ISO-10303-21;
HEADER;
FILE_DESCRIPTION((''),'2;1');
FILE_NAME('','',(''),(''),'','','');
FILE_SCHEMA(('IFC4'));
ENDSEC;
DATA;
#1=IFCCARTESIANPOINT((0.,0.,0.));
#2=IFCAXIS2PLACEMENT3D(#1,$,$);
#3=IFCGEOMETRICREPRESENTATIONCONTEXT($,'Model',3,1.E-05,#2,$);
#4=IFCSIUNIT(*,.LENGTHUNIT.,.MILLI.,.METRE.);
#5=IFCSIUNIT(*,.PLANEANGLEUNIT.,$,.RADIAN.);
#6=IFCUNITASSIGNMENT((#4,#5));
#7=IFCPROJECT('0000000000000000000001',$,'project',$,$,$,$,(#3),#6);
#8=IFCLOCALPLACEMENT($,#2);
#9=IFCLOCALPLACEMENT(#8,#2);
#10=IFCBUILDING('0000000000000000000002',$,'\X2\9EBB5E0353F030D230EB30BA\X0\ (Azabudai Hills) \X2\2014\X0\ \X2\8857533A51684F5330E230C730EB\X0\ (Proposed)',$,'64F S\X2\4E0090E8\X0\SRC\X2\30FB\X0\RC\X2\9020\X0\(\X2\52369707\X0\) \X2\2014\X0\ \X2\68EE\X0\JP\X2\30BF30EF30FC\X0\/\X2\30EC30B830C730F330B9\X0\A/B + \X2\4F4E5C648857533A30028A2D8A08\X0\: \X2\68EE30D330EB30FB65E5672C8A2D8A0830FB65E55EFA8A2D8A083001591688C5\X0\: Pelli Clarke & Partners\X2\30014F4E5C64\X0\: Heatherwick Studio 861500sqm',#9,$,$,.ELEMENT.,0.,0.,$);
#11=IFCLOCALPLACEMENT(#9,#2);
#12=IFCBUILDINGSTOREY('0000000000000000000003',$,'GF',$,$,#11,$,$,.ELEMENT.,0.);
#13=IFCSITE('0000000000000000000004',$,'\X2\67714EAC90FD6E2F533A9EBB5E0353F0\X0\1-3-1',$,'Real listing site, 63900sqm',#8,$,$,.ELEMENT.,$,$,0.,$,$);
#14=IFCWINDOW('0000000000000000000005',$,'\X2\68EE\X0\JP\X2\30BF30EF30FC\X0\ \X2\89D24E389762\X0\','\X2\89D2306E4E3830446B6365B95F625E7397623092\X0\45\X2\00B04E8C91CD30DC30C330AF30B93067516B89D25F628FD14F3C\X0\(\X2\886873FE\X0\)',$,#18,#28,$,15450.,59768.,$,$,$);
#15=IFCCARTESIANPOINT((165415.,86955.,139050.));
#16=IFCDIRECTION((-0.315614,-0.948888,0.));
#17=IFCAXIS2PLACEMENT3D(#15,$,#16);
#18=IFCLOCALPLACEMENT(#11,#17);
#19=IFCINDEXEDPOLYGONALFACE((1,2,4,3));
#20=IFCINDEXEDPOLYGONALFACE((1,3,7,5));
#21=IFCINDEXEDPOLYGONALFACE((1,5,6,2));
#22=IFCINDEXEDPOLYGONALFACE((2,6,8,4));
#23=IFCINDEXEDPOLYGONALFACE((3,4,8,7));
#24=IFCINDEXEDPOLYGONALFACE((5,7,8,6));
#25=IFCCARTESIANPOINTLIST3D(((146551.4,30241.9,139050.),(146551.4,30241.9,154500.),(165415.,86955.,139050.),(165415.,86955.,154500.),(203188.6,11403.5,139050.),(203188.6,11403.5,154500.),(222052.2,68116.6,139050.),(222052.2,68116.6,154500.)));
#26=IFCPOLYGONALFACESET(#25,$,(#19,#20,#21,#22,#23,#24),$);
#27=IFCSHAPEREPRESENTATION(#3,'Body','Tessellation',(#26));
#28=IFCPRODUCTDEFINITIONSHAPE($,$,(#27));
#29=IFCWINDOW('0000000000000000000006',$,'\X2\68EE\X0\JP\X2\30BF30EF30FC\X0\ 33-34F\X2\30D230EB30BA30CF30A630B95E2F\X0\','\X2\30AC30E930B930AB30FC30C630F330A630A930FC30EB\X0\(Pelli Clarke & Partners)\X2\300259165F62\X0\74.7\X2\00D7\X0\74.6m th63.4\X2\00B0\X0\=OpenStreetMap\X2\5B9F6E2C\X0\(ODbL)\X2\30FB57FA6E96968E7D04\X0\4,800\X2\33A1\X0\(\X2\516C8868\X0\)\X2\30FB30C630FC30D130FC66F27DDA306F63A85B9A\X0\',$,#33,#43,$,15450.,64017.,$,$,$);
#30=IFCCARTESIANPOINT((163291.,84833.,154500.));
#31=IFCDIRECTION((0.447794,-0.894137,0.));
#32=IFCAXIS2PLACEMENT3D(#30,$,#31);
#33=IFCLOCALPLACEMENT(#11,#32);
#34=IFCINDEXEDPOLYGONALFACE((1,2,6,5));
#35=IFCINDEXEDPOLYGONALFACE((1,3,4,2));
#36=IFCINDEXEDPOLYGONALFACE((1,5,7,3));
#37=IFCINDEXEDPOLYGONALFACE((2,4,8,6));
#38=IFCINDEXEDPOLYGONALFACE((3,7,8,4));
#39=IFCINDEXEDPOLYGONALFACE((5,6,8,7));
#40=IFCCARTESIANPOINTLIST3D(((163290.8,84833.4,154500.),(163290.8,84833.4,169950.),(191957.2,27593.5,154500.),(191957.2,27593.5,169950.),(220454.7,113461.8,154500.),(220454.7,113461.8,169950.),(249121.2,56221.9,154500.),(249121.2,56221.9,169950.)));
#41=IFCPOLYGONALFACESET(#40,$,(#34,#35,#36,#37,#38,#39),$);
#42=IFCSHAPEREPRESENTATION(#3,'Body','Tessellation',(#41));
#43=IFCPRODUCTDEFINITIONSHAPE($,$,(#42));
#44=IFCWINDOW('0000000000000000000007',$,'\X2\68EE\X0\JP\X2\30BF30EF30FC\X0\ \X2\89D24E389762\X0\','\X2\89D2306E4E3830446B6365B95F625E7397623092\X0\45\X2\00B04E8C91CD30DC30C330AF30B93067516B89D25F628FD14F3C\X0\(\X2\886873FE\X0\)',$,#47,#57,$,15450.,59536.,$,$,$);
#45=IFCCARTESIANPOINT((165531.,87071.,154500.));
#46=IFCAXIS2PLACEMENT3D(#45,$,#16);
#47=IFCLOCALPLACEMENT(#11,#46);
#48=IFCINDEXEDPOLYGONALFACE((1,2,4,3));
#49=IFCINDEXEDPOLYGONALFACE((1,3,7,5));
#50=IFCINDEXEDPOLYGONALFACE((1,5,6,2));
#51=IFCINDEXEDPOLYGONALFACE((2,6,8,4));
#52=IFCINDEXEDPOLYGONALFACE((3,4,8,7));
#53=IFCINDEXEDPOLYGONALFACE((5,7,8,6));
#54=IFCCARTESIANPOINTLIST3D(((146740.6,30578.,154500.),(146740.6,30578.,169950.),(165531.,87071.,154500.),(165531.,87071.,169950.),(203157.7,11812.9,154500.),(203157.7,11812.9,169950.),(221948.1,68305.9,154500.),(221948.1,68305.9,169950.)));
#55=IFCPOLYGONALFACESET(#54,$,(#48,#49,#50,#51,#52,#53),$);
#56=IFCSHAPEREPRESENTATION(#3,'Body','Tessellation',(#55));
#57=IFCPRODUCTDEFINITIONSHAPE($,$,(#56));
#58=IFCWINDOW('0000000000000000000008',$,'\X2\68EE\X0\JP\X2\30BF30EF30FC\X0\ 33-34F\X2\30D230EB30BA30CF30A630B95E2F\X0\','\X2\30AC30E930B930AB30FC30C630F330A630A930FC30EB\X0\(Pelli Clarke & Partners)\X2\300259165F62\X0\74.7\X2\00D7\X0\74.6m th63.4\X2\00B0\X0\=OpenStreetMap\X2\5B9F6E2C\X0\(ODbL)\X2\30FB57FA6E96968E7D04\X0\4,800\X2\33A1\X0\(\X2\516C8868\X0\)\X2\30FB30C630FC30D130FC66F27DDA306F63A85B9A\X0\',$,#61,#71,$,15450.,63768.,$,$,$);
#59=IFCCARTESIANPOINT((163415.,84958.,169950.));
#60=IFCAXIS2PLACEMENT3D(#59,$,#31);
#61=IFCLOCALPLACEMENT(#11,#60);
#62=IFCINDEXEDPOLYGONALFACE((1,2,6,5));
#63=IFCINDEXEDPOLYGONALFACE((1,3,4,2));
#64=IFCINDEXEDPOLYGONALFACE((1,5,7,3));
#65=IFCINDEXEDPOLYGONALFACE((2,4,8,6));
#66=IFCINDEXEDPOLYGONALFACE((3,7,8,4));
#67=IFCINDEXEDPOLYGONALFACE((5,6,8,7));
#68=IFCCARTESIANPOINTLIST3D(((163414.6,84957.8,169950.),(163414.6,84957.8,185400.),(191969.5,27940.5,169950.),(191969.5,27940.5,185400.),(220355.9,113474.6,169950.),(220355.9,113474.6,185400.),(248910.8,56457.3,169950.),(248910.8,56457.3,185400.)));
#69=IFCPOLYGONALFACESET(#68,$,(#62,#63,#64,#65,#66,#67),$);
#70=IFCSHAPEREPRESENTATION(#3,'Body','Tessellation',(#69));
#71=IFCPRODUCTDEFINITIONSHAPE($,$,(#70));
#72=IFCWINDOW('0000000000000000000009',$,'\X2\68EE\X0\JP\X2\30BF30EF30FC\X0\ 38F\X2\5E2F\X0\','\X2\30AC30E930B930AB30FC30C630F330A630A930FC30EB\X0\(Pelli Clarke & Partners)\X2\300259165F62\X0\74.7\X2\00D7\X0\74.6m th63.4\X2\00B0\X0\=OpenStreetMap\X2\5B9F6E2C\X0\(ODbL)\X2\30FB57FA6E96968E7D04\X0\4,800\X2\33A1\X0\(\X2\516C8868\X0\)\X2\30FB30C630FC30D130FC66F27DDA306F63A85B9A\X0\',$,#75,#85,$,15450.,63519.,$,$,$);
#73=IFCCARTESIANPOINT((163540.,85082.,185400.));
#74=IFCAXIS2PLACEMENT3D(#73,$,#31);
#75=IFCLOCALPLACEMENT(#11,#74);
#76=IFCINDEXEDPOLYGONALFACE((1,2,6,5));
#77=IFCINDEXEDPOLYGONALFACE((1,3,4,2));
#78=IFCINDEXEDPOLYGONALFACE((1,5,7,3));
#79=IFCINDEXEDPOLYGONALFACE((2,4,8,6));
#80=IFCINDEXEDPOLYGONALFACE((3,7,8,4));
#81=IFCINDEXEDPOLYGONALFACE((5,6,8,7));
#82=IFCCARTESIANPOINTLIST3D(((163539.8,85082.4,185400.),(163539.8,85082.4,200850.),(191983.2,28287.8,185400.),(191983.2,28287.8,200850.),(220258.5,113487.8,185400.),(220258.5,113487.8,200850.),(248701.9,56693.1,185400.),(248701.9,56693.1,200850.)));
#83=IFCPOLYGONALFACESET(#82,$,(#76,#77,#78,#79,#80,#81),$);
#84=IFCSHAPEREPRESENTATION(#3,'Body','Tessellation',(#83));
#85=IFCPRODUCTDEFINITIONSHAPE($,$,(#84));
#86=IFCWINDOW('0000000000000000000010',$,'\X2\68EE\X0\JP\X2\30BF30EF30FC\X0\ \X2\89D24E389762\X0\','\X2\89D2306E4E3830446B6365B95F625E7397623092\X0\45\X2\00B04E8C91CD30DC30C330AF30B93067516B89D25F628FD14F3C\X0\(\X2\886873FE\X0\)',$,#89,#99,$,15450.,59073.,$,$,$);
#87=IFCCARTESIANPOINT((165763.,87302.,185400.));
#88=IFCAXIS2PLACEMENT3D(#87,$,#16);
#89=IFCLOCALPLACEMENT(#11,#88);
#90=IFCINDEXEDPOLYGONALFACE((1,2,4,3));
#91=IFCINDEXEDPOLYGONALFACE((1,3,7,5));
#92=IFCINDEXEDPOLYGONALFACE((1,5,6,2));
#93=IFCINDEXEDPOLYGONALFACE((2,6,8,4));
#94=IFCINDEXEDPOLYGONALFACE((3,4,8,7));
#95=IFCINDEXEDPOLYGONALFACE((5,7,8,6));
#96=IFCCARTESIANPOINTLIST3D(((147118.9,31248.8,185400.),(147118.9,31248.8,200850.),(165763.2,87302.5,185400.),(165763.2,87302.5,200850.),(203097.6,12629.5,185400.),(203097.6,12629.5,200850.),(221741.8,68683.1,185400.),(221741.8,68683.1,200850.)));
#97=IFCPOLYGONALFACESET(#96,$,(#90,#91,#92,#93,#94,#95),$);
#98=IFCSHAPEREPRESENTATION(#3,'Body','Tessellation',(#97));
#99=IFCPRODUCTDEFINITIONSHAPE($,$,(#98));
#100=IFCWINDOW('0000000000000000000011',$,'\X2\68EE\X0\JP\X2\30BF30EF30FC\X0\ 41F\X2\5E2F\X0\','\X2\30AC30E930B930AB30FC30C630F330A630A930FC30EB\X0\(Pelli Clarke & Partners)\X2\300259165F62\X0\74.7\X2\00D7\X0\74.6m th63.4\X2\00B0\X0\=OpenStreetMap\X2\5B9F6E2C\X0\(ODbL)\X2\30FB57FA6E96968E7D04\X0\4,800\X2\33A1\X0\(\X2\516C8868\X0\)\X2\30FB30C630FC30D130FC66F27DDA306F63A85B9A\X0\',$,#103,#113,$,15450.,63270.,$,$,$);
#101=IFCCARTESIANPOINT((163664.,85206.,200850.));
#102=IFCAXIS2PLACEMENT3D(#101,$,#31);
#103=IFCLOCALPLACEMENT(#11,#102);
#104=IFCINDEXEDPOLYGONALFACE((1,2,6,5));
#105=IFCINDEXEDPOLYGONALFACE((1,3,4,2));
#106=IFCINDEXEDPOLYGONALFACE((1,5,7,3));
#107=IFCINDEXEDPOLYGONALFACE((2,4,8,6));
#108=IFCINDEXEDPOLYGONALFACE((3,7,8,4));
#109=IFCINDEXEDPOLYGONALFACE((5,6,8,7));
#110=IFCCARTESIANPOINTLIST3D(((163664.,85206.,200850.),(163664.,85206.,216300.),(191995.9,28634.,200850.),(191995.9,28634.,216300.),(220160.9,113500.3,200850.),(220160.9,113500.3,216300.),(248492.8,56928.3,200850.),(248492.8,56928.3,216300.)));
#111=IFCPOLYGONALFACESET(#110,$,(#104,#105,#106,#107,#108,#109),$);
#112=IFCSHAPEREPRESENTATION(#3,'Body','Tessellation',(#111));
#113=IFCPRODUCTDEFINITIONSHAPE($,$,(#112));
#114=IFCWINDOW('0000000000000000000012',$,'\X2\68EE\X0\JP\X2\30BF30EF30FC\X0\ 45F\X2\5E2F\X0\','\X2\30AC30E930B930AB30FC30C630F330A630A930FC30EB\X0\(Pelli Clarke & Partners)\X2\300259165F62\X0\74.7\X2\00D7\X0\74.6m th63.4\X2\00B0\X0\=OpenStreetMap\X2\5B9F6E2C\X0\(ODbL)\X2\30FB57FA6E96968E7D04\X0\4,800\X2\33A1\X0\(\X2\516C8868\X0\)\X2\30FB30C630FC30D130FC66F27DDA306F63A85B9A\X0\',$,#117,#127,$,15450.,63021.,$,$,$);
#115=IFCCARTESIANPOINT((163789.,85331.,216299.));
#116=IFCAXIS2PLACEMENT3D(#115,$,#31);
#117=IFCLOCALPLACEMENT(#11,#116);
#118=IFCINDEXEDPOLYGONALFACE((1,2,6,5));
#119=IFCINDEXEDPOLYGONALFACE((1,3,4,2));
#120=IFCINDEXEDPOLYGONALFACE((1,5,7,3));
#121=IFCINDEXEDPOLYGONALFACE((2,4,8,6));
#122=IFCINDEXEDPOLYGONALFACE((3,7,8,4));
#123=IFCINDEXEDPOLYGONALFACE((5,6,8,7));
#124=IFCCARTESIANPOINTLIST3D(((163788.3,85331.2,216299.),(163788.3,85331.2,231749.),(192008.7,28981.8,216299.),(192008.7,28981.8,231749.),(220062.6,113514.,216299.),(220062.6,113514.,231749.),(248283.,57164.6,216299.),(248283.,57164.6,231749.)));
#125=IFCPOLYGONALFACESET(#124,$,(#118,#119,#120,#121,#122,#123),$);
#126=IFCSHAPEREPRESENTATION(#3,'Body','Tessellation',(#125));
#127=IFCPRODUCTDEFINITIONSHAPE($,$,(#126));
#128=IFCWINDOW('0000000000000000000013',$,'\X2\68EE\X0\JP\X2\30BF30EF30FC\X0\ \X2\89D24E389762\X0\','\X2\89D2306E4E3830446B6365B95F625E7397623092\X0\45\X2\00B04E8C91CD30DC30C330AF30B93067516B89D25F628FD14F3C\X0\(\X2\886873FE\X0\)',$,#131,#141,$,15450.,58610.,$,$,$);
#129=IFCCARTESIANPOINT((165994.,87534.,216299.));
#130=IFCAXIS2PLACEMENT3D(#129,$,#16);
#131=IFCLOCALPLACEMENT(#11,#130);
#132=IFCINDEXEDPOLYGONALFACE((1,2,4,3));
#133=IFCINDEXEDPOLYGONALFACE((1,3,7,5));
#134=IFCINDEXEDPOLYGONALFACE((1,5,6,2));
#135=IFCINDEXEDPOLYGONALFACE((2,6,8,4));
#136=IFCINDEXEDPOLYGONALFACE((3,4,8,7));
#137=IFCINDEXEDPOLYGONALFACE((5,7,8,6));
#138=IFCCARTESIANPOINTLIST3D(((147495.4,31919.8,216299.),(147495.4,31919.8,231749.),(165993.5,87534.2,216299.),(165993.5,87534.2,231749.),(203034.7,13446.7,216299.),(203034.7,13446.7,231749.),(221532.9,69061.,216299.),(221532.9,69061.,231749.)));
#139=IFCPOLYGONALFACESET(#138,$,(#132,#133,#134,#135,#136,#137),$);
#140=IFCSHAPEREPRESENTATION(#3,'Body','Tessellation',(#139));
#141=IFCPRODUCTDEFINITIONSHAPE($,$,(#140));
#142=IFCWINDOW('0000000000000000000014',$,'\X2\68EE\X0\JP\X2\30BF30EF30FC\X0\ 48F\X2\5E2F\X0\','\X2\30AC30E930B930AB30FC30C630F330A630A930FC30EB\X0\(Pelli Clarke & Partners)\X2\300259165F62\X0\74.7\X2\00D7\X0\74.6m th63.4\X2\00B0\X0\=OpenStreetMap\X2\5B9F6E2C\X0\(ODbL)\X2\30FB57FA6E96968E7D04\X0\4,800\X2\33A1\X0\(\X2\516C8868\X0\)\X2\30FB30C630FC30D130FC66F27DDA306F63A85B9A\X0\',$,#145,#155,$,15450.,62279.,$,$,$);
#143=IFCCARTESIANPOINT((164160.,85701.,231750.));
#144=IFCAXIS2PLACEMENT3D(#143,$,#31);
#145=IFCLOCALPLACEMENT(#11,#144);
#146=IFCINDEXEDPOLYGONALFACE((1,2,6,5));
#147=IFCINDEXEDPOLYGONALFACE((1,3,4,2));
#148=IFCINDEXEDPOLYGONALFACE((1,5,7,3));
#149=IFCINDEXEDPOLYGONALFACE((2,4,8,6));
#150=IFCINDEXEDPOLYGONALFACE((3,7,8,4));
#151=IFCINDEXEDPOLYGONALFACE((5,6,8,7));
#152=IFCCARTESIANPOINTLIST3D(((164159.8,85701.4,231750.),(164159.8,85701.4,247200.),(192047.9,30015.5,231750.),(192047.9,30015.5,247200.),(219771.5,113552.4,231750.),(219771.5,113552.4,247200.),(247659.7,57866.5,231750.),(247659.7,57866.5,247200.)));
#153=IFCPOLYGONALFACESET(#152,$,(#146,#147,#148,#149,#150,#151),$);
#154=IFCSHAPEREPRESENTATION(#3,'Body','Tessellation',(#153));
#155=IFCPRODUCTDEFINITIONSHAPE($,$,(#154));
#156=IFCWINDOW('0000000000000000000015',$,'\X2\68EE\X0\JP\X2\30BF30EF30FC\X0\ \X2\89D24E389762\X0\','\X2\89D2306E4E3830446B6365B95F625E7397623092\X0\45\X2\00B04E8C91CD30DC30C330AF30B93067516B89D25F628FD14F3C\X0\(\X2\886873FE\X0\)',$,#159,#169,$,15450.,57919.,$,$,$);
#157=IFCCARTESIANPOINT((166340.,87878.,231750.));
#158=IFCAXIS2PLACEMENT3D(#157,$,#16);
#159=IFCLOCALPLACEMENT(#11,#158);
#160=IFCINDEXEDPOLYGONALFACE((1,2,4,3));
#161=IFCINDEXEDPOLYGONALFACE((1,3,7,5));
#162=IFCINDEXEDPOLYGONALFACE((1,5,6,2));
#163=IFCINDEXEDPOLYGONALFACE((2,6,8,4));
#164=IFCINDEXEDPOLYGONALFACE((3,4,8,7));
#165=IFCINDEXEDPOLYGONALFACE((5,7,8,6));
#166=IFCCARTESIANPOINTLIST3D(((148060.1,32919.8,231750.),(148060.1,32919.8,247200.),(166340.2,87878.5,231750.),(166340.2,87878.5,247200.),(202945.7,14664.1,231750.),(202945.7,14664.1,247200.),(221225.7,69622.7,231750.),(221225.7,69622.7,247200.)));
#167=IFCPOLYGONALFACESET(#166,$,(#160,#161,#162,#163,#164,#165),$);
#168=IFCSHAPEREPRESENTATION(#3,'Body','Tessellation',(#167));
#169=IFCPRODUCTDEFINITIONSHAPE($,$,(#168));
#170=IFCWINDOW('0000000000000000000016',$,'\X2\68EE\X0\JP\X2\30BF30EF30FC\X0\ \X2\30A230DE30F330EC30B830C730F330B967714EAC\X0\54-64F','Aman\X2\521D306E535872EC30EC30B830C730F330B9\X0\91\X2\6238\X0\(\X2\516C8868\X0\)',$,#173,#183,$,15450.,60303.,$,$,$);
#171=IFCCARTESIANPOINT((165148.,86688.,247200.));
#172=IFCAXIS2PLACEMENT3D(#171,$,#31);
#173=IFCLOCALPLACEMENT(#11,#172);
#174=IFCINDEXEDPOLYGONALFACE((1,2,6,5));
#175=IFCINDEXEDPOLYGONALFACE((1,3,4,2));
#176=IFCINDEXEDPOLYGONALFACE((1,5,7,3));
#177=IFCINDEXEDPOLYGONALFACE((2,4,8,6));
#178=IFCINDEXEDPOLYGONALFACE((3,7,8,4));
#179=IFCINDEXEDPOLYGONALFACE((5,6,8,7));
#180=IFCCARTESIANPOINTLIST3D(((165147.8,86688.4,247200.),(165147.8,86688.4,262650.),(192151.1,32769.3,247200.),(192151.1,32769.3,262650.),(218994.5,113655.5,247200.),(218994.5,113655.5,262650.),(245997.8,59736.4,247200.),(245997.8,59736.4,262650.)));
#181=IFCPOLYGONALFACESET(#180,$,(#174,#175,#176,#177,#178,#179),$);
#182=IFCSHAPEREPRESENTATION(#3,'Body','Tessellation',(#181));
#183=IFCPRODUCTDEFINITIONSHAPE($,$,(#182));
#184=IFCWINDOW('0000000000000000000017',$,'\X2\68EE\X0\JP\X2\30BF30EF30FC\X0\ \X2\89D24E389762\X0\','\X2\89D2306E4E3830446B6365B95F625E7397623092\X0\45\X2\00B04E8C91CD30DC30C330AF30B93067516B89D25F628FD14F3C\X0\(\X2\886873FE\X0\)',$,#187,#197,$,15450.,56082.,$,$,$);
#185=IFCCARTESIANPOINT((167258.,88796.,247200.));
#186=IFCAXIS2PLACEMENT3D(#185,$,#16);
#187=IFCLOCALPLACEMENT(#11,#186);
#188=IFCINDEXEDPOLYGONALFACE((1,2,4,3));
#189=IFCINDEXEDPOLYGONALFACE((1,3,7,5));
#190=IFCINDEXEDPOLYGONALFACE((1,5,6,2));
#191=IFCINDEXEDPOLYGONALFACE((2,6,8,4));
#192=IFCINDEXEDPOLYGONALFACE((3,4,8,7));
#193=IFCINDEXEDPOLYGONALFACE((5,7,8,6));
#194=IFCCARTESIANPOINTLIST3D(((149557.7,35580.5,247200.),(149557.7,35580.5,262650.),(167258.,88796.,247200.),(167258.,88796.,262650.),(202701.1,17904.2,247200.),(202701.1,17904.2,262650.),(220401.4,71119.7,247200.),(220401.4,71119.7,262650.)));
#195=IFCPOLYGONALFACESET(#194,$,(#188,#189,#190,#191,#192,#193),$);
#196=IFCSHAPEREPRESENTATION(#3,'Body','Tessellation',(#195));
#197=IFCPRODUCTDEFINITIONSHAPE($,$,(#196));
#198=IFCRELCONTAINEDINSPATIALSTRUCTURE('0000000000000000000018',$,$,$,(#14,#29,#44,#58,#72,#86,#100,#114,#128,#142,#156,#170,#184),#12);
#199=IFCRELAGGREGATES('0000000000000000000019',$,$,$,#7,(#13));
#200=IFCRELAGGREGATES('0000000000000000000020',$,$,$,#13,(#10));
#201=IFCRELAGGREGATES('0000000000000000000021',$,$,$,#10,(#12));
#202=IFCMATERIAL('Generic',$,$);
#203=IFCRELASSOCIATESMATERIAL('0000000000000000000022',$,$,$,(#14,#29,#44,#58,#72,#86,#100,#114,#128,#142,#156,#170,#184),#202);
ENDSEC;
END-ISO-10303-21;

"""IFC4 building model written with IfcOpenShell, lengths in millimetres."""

from ifc_helpers import new_model, si_unit, frame, frame_2d, origin, place, context, project, spatial, rectangle, extrude, material, element, save


model = new_model("IFC4")

# Units and contexts
model_context = context("Model", 3, precision=1e-05, world=origin())
ifc_project = project(units=[si_unit("LENGTHUNIT", "METRE", prefix="MILLI"), si_unit("PLANEANGLEUNIT", "RADIAN")], contexts=[model_context])

# Site, building, storey
site_placement = place(None, origin())
site = spatial("IfcSite", under=ifc_project, at=site_placement, Name="東京都港区麻布台1-3-1", ObjectType="Real listing site, 63900sqm", CompositionType="ELEMENT", RefElevation=0.0)
building_placement = place(site_placement, origin())
building = spatial("IfcBuilding", under=site, at=building_placement, Name="麻布台ヒルズ (Azabudai Hills) — 街区全体モデル (Proposed)", ObjectType="64F S一部SRC・RC造(制震) — 森JPタワー/レジデンスA/B + 低層街区。設計: 森ビル・日本設計・日建設計、外装: Pelli Clarke & Partners、低層: Heatherwick Studio 861500sqm", CompositionType="ELEMENT", ElevationOfRefHeight=0.0, ElevationOfTerrain=0.0)
storey_placement = place(building_placement, origin())
storey = spatial("IfcBuildingStorey", under=building, at=storey_placement, Name="GF", CompositionType="ELEMENT", Elevation=0.0)

# Windows
ifc_material = material(Name="Generic")
window_1_placement = place(storey_placement, frame((165415.0, 86955.0, 139050.0), x_axis=(-0.315614, -0.948888, 0.0)))
element("IfcWindow", 1, at=window_1_placement, inside=storey, material=ifc_material, Name="森JPタワー 角丸面", Description="角の丸い正方形平面を45°二重ボックスで八角形近似(表現)", OverallHeight=15450.0, OverallWidth=59768.0, context=model_context, shape_type="SweptSolid", body=[
    extrude(rectangle(XDim=59768.0, YDim=59688.0, at=frame_2d((29884.0, 29844.0))), frame((165415.0, 86955.0, 139050.0), x_axis=(-0.315614, -0.948888, 0.0)), (0.0, 0.0, 1.0), 15450.0),
])
window_2_placement = place(storey_placement, frame((163291.0, 84833.0, 154500.0), x_axis=(0.447794, -0.894137, 0.0)))
element("IfcWindow", 2, at=window_2_placement, inside=storey, material=ifc_material, Name="森JPタワー 33-34Fヒルズハウス帯", Description="ガラスカーテンウォール(Pelli Clarke & Partners)。外形74.7×74.6m th63.4°=OpenStreetMap実測(ODbL)・基準階約4,800㎡(公表)・テーパー曲線は推定", OverallHeight=15450.0, OverallWidth=64017.0, context=model_context, shape_type="SweptSolid", body=[
    extrude(rectangle(XDim=64017.0, YDim=63932.0, at=frame_2d((32008.0, 31966.0))), frame((163291.0, 84833.0, 154500.0), x_axis=(0.447794, -0.894137, 0.0)), (0.0, 0.0, 1.0), 15450.0),
])
window_3_placement = place(storey_placement, frame((165531.0, 87071.0, 154500.0), x_axis=(-0.315614, -0.948888, 0.0)))
element("IfcWindow", 3, at=window_3_placement, inside=storey, material=ifc_material, Name="森JPタワー 角丸面", Description="角の丸い正方形平面を45°二重ボックスで八角形近似(表現)", OverallHeight=15450.0, OverallWidth=59536.0, context=model_context, shape_type="SweptSolid", body=[
    extrude(rectangle(XDim=59536.0, YDim=59456.0, at=frame_2d((29768.0, 29728.0))), frame((165531.0, 87071.0, 154500.0), x_axis=(-0.315614, -0.948888, 0.0)), (0.0, 0.0, 1.0), 15450.0),
])
window_4_placement = place(storey_placement, frame((163415.0, 84958.0, 169950.0), x_axis=(0.447794, -0.894137, 0.0)))
element("IfcWindow", 4, at=window_4_placement, inside=storey, material=ifc_material, Name="森JPタワー 33-34Fヒルズハウス帯", Description="ガラスカーテンウォール(Pelli Clarke & Partners)。外形74.7×74.6m th63.4°=OpenStreetMap実測(ODbL)・基準階約4,800㎡(公表)・テーパー曲線は推定", OverallHeight=15450.0, OverallWidth=63768.0, context=model_context, shape_type="SweptSolid", body=[
    extrude(rectangle(XDim=63768.0, YDim=63683.0, at=frame_2d((31884.0, 31841.0))), frame((163415.0, 84958.0, 169950.0), x_axis=(0.447794, -0.894137, 0.0)), (0.0, 0.0, 1.0), 15450.0),
])
window_5_placement = place(storey_placement, frame((163540.0, 85082.0, 185400.0), x_axis=(0.447794, -0.894137, 0.0)))
element("IfcWindow", 5, at=window_5_placement, inside=storey, material=ifc_material, Name="森JPタワー 38F帯", Description="ガラスカーテンウォール(Pelli Clarke & Partners)。外形74.7×74.6m th63.4°=OpenStreetMap実測(ODbL)・基準階約4,800㎡(公表)・テーパー曲線は推定", OverallHeight=15450.0, OverallWidth=63519.0, context=model_context, shape_type="SweptSolid", body=[
    extrude(rectangle(XDim=63519.0, YDim=63434.0, at=frame_2d((31759.0, 31717.0))), frame((163540.0, 85082.0, 185400.0), x_axis=(0.447794, -0.894137, 0.0)), (0.0, 0.0, 1.0), 15450.0),
])
window_6_placement = place(storey_placement, frame((165763.0, 87302.0, 185400.0), x_axis=(-0.315614, -0.948888, 0.0)))
element("IfcWindow", 6, at=window_6_placement, inside=storey, material=ifc_material, Name="森JPタワー 角丸面", Description="角の丸い正方形平面を45°二重ボックスで八角形近似(表現)", OverallHeight=15450.0, OverallWidth=59073.0, context=model_context, shape_type="SweptSolid", body=[
    extrude(rectangle(XDim=59073.0, YDim=58994.0, at=frame_2d((29536.0, 29497.0))), frame((165763.0, 87302.0, 185400.0), x_axis=(-0.315614, -0.948888, 0.0)), (0.0, 0.0, 1.0), 15450.0),
])
window_7_placement = place(storey_placement, frame((163664.0, 85206.0, 200850.0), x_axis=(0.447794, -0.894137, 0.0)))
element("IfcWindow", 7, at=window_7_placement, inside=storey, material=ifc_material, Name="森JPタワー 41F帯", Description="ガラスカーテンウォール(Pelli Clarke & Partners)。外形74.7×74.6m th63.4°=OpenStreetMap実測(ODbL)・基準階約4,800㎡(公表)・テーパー曲線は推定", OverallHeight=15450.0, OverallWidth=63270.0, context=model_context, shape_type="SweptSolid", body=[
    extrude(rectangle(XDim=63270.0, YDim=63186.0, at=frame_2d((31635.0, 31593.0))), frame((163664.0, 85206.0, 200850.0), x_axis=(0.447794, -0.894137, 0.0)), (0.0, 0.0, 1.0), 15450.0),
])
window_8_placement = place(storey_placement, frame((163789.0, 85331.0, 216299.0), x_axis=(0.447794, -0.894137, 0.0)))
element("IfcWindow", 8, at=window_8_placement, inside=storey, material=ifc_material, Name="森JPタワー 45F帯", Description="ガラスカーテンウォール(Pelli Clarke & Partners)。外形74.7×74.6m th63.4°=OpenStreetMap実測(ODbL)・基準階約4,800㎡(公表)・テーパー曲線は推定", OverallHeight=15450.0, OverallWidth=63021.0, context=model_context, shape_type="SweptSolid", body=[
    extrude(rectangle(XDim=63021.0, YDim=62937.0, at=frame_2d((31510.0, 31468.0))), frame((163789.0, 85331.0, 216299.0), x_axis=(0.447794, -0.894137, 0.0)), (0.0, 0.0, 1.0), 15450.0),
])
window_9_placement = place(storey_placement, frame((165994.0, 87534.0, 216299.0), x_axis=(-0.315614, -0.948888, 0.0)))
element("IfcWindow", 9, at=window_9_placement, inside=storey, material=ifc_material, Name="森JPタワー 角丸面", Description="角の丸い正方形平面を45°二重ボックスで八角形近似(表現)", OverallHeight=15450.0, OverallWidth=58610.0, context=model_context, shape_type="SweptSolid", body=[
    extrude(rectangle(XDim=58610.0, YDim=58531.0, at=frame_2d((29305.0, 29265.0))), frame((165994.0, 87534.0, 216299.0), x_axis=(-0.315614, -0.948888, 0.0)), (0.0, 0.0, 1.0), 15450.0),
])
window_10_placement = place(storey_placement, frame((164160.0, 85701.0, 231750.0), x_axis=(0.447794, -0.894137, 0.0)))
element("IfcWindow", 10, at=window_10_placement, inside=storey, material=ifc_material, Name="森JPタワー 48F帯", Description="ガラスカーテンウォール(Pelli Clarke & Partners)。外形74.7×74.6m th63.4°=OpenStreetMap実測(ODbL)・基準階約4,800㎡(公表)・テーパー曲線は推定", OverallHeight=15450.0, OverallWidth=62279.0, context=model_context, shape_type="SweptSolid", body=[
    extrude(rectangle(XDim=62279.0, YDim=62196.0, at=frame_2d((31139.0, 31098.0))), frame((164160.0, 85701.0, 231750.0), x_axis=(0.447794, -0.894137, 0.0)), (0.0, 0.0, 1.0), 15450.0),
])
window_11_placement = place(storey_placement, frame((166340.0, 87878.0, 231750.0), x_axis=(-0.315614, -0.948888, 0.0)))
element("IfcWindow", 11, at=window_11_placement, inside=storey, material=ifc_material, Name="森JPタワー 角丸面", Description="角の丸い正方形平面を45°二重ボックスで八角形近似(表現)", OverallHeight=15450.0, OverallWidth=57919.0, context=model_context, shape_type="SweptSolid", body=[
    extrude(rectangle(XDim=57919.0, YDim=57842.0, at=frame_2d((28959.0, 28921.0))), frame((166340.0, 87878.0, 231750.0), x_axis=(-0.315614, -0.948888, 0.0)), (0.0, 0.0, 1.0), 15450.0),
])
window_12_placement = place(storey_placement, frame((165148.0, 86688.0, 247200.0), x_axis=(0.447794, -0.894137, 0.0)))
element("IfcWindow", 12, at=window_12_placement, inside=storey, material=ifc_material, Name="森JPタワー アマンレジデンス東京54-64F", Description="Aman初の単独レジデンス91戸(公表)", OverallHeight=15450.0, OverallWidth=60303.0, context=model_context, shape_type="SweptSolid", body=[
    extrude(rectangle(XDim=60303.0, YDim=60222.0, at=frame_2d((30151.0, 30111.0))), frame((165148.0, 86688.0, 247200.0), x_axis=(0.447794, -0.894137, 0.0)), (0.0, 0.0, 1.0), 15450.0),
])
window_13_placement = place(storey_placement, frame((167258.0, 88796.0, 247200.0), x_axis=(-0.315614, -0.948888, 0.0)))
element("IfcWindow", 13, at=window_13_placement, inside=storey, material=ifc_material, Name="森JPタワー 角丸面", Description="角の丸い正方形平面を45°二重ボックスで八角形近似(表現)", OverallHeight=15450.0, OverallWidth=56082.0, context=model_context, shape_type="SweptSolid", body=[
    extrude(rectangle(XDim=56082.0, YDim=56006.0, at=frame_2d((28041.0, 28003.0))), frame((167258.0, 88796.0, 247200.0), x_axis=(-0.315614, -0.948888, 0.0)), (0.0, 0.0, 1.0), 15450.0),
])

save(model, "model.ifc")
